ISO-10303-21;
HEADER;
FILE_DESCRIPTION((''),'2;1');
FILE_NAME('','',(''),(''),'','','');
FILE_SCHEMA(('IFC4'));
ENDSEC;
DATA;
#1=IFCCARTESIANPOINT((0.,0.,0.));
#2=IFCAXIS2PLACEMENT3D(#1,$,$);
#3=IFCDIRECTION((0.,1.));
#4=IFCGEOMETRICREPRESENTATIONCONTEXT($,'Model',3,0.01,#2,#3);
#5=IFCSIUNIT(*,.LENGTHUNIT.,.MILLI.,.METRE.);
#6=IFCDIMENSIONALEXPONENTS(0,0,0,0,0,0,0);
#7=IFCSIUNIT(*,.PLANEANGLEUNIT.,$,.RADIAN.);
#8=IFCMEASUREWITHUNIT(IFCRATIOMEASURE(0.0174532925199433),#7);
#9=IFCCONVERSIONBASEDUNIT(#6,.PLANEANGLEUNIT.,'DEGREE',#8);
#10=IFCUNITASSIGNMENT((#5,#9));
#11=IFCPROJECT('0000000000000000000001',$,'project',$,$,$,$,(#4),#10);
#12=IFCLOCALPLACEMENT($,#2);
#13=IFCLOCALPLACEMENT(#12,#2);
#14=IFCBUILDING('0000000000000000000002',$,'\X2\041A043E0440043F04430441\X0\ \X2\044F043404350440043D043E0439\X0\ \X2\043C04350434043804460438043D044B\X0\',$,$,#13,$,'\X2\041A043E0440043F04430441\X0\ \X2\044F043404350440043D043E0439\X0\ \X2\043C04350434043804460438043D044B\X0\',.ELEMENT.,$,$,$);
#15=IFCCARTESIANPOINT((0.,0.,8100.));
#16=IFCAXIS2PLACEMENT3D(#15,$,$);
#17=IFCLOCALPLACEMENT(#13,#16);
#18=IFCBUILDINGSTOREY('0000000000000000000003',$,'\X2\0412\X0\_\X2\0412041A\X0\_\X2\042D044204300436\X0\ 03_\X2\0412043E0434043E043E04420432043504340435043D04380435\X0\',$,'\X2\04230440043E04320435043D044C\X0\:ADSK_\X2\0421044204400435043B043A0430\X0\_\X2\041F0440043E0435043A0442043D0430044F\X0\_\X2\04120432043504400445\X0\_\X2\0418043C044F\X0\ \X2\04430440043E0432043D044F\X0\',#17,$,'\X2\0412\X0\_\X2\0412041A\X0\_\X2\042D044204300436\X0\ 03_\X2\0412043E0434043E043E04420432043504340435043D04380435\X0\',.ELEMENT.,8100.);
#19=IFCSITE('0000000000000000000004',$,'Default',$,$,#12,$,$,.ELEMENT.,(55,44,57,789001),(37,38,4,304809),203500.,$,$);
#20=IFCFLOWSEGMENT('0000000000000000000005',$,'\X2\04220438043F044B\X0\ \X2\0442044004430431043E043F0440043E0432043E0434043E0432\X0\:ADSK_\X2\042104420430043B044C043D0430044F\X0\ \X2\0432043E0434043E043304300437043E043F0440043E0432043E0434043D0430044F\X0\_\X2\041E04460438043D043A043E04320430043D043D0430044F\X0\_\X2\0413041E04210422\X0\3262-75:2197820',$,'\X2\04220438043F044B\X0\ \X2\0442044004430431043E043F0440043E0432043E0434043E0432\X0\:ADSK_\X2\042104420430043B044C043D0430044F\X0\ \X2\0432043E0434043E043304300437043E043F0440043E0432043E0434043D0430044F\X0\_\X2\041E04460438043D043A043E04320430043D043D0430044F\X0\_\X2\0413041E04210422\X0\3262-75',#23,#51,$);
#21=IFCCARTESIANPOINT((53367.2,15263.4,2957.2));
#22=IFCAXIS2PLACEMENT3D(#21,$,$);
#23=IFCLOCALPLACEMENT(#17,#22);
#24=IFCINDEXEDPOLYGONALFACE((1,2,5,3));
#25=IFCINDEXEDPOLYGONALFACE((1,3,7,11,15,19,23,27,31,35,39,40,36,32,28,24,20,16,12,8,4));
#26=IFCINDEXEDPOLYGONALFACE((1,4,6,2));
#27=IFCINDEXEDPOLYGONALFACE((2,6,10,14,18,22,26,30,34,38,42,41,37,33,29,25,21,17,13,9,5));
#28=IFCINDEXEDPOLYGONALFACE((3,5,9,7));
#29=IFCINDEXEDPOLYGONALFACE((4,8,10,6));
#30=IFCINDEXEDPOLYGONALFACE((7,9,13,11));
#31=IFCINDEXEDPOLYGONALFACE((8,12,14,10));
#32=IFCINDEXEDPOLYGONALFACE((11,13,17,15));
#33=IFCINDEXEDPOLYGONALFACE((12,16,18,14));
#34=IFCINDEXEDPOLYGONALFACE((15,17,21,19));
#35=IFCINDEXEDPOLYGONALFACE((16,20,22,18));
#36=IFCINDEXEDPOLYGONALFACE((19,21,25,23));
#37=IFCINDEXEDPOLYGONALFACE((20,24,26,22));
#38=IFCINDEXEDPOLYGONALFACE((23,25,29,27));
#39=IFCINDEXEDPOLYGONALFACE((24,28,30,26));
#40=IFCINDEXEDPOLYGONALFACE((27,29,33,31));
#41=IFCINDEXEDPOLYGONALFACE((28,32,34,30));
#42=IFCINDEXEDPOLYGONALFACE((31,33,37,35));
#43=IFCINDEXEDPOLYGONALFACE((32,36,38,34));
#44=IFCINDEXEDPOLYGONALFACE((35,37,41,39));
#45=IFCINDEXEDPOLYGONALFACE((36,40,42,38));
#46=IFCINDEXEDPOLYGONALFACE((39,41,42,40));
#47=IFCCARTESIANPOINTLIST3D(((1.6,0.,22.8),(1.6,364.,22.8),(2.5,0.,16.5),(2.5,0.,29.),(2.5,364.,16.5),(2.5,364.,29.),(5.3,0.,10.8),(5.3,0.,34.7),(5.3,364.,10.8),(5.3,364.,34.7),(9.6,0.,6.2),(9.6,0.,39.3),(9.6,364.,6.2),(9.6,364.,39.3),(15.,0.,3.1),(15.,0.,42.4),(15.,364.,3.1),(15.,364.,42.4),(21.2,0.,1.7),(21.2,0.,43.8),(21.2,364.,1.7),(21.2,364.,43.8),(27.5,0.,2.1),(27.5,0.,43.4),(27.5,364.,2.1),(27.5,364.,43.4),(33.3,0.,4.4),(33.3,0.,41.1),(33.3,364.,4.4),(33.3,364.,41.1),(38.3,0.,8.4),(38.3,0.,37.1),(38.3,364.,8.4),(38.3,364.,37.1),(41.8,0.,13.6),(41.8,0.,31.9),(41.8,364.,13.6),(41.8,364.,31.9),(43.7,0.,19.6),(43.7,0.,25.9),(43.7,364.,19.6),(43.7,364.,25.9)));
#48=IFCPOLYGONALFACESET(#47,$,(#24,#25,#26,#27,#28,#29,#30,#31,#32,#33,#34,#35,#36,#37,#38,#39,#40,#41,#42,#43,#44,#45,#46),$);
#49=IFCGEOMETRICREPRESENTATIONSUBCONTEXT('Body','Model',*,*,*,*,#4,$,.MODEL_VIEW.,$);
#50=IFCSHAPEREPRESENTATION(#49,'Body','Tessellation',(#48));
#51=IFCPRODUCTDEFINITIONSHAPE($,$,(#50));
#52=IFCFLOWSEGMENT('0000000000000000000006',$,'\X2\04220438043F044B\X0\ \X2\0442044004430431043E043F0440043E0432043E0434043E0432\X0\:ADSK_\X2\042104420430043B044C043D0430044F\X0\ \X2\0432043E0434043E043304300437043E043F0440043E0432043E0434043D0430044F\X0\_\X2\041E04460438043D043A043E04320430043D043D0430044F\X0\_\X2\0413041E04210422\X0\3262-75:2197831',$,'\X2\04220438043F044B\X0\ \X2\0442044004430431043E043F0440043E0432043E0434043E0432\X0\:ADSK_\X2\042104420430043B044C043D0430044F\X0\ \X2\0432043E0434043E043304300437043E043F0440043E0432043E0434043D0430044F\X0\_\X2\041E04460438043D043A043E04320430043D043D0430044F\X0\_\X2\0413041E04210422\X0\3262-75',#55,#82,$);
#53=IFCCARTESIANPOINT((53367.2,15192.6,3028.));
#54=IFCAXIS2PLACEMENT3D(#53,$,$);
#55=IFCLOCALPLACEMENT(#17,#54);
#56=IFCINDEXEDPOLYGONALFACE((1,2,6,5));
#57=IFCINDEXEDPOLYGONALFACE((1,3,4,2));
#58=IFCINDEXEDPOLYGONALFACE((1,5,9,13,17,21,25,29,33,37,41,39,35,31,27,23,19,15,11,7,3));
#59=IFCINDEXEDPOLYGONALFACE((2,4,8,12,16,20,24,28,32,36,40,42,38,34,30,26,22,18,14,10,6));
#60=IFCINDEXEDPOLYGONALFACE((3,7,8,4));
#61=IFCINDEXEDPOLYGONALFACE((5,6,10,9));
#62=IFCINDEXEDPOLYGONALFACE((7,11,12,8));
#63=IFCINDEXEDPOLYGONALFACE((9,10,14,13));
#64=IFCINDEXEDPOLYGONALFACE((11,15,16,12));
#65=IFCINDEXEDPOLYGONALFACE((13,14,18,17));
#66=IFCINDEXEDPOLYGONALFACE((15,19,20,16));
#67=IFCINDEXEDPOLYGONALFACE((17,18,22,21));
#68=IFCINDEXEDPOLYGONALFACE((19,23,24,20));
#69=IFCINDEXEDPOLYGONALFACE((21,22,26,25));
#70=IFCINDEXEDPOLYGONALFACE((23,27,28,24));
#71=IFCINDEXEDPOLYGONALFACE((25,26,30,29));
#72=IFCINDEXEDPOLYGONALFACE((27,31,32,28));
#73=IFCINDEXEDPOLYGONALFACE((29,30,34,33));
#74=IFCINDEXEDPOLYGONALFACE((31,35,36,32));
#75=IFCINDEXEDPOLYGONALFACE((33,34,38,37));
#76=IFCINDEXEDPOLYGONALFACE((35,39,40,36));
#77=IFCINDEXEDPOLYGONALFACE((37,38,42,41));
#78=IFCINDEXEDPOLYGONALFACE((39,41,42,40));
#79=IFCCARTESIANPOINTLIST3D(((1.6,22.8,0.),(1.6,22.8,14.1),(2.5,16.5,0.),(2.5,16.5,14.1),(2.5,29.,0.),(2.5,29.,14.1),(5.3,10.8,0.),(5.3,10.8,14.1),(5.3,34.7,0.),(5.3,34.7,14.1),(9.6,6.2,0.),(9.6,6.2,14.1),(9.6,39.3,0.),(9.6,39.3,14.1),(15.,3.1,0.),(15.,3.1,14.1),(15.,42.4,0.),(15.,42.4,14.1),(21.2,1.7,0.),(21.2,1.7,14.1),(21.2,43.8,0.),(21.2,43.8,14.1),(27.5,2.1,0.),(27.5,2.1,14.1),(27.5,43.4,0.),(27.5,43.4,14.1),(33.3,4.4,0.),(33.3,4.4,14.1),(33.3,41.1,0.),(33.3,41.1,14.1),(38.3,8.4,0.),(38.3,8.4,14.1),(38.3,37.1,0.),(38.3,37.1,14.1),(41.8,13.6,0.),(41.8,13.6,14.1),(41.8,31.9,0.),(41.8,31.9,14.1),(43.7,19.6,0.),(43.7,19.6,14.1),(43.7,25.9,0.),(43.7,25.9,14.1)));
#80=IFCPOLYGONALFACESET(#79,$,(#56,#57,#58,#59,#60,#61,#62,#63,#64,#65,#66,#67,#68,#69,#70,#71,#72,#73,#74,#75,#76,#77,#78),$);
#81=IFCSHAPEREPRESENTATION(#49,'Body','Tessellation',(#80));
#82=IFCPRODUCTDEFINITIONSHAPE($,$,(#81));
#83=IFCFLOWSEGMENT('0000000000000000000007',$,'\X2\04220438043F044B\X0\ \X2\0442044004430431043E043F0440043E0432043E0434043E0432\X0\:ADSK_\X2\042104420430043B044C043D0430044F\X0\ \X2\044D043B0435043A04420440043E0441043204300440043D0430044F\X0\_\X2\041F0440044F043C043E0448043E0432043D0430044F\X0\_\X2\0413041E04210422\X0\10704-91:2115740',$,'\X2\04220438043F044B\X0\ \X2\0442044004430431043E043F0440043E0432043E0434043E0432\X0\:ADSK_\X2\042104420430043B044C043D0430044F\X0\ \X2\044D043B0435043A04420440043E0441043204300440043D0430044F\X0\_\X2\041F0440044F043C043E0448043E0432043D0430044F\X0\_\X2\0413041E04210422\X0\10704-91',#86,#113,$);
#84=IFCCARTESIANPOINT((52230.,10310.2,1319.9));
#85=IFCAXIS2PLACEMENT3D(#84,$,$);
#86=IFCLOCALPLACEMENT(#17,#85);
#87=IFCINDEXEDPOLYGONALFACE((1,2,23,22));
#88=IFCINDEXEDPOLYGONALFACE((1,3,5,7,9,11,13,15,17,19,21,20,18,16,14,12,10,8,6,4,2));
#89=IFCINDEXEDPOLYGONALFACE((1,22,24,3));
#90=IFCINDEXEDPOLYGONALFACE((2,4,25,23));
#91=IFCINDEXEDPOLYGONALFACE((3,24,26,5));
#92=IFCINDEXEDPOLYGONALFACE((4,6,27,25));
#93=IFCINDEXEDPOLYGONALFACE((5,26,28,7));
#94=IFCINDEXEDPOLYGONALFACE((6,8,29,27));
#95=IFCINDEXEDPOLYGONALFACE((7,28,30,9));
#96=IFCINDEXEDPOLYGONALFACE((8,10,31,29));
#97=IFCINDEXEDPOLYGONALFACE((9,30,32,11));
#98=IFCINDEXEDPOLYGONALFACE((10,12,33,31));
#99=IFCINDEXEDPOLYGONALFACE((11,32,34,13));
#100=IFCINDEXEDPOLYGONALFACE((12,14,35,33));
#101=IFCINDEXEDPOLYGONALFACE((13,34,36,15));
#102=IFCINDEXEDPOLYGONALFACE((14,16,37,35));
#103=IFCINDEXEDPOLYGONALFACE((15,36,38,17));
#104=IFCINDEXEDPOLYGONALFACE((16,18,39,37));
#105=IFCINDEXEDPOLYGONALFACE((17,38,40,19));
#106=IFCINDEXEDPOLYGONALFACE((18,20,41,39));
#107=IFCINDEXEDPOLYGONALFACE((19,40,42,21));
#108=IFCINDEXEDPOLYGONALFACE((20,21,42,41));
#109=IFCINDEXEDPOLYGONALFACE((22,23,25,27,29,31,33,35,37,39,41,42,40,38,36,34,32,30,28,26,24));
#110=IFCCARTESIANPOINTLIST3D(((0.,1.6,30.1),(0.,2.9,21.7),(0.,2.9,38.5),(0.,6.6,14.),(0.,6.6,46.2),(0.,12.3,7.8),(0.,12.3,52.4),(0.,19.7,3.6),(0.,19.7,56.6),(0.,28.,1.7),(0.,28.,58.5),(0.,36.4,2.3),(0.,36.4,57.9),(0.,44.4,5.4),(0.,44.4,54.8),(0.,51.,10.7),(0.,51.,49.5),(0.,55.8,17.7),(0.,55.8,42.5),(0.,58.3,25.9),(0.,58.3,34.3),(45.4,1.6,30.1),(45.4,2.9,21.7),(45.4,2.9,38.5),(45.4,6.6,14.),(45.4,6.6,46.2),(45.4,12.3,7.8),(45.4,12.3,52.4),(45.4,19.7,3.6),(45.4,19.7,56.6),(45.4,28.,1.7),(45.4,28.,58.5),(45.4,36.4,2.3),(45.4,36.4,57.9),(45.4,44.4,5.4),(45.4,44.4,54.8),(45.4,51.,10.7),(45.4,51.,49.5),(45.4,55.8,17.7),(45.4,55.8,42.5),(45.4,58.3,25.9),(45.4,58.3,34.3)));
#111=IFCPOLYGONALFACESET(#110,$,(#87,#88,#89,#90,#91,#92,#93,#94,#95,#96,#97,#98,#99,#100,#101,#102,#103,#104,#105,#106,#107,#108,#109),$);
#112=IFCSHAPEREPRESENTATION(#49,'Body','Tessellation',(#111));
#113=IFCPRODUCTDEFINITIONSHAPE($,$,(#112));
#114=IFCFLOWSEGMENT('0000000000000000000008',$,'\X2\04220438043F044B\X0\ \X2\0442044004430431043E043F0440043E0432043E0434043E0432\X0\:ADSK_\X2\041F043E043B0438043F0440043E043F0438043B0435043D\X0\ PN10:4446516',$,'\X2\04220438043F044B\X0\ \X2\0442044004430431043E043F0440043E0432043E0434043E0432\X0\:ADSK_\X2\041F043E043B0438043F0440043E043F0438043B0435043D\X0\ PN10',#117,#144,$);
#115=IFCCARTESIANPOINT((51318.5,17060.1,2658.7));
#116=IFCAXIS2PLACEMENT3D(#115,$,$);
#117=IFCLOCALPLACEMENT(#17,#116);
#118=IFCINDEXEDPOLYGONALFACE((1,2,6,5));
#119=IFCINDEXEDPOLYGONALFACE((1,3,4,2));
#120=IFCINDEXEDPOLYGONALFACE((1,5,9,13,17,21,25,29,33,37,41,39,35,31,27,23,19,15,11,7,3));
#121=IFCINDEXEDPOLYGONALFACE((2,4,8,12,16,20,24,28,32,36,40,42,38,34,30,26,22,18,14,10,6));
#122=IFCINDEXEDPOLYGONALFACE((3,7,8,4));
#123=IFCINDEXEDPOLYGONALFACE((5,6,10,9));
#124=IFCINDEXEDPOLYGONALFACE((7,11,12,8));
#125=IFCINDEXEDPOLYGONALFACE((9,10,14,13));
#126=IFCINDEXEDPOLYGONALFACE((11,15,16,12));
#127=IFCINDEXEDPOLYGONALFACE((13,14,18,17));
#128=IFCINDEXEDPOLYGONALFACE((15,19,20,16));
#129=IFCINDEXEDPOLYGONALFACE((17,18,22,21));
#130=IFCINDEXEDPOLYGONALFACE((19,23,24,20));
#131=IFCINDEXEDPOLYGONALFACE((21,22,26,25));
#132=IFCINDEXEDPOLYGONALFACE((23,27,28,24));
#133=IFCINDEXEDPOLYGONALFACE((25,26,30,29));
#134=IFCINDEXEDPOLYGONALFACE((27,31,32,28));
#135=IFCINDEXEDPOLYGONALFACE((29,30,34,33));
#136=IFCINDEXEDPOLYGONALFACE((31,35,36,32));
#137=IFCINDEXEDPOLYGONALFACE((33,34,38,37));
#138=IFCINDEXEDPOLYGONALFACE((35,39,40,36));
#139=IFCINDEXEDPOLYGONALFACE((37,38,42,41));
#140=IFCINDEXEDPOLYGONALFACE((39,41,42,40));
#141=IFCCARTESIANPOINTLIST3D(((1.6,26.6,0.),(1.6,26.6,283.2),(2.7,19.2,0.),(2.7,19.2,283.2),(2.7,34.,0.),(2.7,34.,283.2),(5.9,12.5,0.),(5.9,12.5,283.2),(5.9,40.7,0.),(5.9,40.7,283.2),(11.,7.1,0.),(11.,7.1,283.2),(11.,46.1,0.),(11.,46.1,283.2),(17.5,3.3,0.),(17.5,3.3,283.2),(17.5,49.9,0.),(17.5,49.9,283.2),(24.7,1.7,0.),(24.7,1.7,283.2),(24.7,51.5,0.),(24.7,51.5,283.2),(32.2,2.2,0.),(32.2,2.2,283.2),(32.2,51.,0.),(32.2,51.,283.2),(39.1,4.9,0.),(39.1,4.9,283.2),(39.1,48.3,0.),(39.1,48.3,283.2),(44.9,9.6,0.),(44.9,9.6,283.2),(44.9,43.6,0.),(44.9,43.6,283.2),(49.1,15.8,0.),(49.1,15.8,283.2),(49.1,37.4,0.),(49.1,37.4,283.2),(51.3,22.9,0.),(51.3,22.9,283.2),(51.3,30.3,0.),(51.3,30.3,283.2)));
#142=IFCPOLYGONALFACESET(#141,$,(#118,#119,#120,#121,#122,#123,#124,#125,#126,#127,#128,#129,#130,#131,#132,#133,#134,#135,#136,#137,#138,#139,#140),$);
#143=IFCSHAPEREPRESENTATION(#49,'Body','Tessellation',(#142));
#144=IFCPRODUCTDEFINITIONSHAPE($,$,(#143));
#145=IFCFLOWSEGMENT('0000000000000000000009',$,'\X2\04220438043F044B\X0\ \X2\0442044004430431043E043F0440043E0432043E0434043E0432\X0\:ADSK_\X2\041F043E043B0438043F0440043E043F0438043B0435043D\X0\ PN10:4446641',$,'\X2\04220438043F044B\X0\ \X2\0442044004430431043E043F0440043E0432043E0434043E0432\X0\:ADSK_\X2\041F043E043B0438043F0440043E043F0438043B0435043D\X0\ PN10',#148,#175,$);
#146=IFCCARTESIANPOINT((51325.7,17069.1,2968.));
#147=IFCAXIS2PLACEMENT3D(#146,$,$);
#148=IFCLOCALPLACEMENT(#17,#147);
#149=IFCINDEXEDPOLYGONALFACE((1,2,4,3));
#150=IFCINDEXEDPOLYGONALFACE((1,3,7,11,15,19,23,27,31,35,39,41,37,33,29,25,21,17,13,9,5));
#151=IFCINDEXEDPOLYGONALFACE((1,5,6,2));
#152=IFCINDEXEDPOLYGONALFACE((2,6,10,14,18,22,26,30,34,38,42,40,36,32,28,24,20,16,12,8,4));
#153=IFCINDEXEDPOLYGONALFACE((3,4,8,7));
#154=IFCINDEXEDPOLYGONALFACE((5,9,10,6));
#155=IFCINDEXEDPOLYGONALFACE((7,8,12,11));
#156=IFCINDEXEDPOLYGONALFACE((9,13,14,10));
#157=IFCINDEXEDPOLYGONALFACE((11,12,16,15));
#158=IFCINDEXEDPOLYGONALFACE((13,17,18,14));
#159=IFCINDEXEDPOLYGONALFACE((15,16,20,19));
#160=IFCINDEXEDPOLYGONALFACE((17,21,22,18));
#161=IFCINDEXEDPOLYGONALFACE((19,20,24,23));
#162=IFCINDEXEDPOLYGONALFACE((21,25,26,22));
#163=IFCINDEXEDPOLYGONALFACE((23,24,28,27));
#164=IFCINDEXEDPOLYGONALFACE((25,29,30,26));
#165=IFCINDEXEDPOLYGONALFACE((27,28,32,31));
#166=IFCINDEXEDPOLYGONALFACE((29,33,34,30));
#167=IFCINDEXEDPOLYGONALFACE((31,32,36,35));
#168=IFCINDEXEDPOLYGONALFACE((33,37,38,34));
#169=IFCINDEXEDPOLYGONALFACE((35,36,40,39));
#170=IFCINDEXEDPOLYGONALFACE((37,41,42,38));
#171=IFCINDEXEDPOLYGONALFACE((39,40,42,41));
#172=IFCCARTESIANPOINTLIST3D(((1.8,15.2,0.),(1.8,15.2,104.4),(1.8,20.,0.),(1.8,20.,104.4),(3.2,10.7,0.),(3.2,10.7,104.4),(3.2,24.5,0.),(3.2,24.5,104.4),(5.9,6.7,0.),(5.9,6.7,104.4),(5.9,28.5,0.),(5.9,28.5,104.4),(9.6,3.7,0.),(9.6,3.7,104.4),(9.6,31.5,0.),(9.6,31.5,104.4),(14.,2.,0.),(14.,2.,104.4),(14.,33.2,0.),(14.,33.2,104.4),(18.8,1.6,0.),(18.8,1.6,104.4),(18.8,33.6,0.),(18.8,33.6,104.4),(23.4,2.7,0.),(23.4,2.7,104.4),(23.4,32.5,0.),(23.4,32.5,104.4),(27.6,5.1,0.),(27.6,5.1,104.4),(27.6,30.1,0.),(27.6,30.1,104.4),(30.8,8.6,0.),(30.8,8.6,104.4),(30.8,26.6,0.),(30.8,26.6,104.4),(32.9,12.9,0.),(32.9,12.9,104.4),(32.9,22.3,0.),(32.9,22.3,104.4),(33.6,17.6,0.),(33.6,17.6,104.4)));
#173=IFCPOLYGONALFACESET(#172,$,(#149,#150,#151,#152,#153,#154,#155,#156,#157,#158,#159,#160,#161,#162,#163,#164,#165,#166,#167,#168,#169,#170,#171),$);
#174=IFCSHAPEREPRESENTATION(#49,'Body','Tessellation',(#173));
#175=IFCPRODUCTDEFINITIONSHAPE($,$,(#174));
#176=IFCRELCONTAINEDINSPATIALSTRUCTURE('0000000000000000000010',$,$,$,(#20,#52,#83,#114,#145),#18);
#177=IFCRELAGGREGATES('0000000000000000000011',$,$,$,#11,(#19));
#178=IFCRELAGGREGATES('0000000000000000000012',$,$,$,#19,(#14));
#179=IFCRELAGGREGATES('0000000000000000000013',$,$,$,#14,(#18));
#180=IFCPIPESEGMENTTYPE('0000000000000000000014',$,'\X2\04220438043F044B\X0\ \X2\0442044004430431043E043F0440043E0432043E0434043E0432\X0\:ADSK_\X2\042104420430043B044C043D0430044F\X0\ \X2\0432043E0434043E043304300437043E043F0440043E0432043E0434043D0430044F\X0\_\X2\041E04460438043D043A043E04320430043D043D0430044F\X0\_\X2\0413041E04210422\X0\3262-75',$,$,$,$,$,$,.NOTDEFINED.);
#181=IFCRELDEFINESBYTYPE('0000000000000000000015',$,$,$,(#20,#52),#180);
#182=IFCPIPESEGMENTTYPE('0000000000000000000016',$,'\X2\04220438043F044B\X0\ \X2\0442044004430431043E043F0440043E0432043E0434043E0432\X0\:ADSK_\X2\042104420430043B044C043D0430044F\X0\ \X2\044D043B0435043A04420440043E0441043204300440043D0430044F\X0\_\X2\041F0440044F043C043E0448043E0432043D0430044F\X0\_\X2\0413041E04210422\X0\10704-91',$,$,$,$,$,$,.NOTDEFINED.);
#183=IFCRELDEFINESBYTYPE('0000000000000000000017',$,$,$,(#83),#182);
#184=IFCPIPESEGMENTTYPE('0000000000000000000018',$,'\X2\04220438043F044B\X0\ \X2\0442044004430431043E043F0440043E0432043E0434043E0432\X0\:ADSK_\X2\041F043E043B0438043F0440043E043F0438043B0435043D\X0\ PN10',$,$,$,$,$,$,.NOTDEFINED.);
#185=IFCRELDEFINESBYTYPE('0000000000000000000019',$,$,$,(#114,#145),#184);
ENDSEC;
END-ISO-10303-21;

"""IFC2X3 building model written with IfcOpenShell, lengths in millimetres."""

from ifc_helpers import new_model, entity, si_unit, converted_unit, direction, frame, origin, origin_2d_with_axis, place, context, subcontext, project, spatial, circle, extrude, type_object, element, save


model = new_model("IFC2X3")

# Units and contexts
model_context = context("Model", 3, precision=0.01, world=origin(), true_north=direction((0.0, 1.0)))
body_context = subcontext(model_context, "Body", "Model", "MODEL_VIEW")
ifc_project = project(units=[si_unit("LENGTHUNIT", "METRE", prefix="MILLI"), converted_unit("PLANEANGLEUNIT", "DEGREE", entity("IfcRatioMeasure", 0.0174532925199433), si_unit("PLANEANGLEUNIT", "RADIAN"), dimensions=[0, 0, 0, 0, 0, 0, 0])], contexts=[model_context])

# Site, building, storey
site_placement = place(None, origin())
site = spatial("IfcSite", under=ifc_project, at=site_placement, Name="Default", CompositionType="ELEMENT", RefLatitude=(55, 44, 57, 789001), RefLongitude=(37, 38, 4, 304809), RefElevation=203500.0)
building_placement = place(site_placement, origin())
building = spatial("IfcBuilding", under=site, at=building_placement, Name="Корпус ядерной медицины", LongName="Корпус ядерной медицины", CompositionType="ELEMENT")
storey_placement = place(building_placement, frame((0.0, 0.0, 8100.0)))
storey = spatial("IfcBuildingStorey", under=building, at=storey_placement, Name="В_ВК_Этаж 03_Водоотведение", ObjectType="Уровень:ADSK_Стрелка_Проектная_Вверх_Имя уровня", LongName="В_ВК_Этаж 03_Водоотведение", CompositionType="ELEMENT", Elevation=8100.0)

# Flow segments
pipe_segment_type_1 = type_object("IfcPipeSegmentType", Name="Типы трубопроводов:ADSK_Стальная водогазопроводная_Оцинкованная_ГОСТ3262-75", PredefinedType="NOTDEFINED")
flow_segment_1_placement = place(storey_placement, frame((53367.2, 15263.4, 2957.2)))
element("IfcFlowSegment", 1, at=flow_segment_1_placement, inside=storey, type_object=pipe_segment_type_1, Name="Типы трубопроводов:ADSK_Стальная водогазопроводная_Оцинкованная_ГОСТ3262-75:2197820", ObjectType="Типы трубопроводов:ADSK_Стальная водогазопроводная_Оцинкованная_ГОСТ3262-75", context=body_context, shape_type="SweptSolid", body=[
    extrude(circle(Radius=21.1, at=origin_2d_with_axis()), frame((22.8, 0.0, 22.8), z_axis=(0.0, 1.0, 0.0), x_axis=(-1.0, 0.0, 0.0)), (0.0, 0.0, 1.0), 364.0),
])
flow_segment_2_placement = place(storey_placement, frame((53367.2, 15192.6, 3028.0)))
element("IfcFlowSegment", 2, at=flow_segment_2_placement, inside=storey, type_object=pipe_segment_type_1, Name="Типы трубопроводов:ADSK_Стальная водогазопроводная_Оцинкованная_ГОСТ3262-75:2197831", ObjectType="Типы трубопроводов:ADSK_Стальная водогазопроводная_Оцинкованная_ГОСТ3262-75", context=body_context, shape_type="SweptSolid", body=[
    extrude(circle(Radius=21.1, at=origin_2d_with_axis()), frame((22.8, 22.8, 0.0), z_axis=(0.0, 0.0, 1.0), x_axis=(-1.0, 0.0, 0.0)), (0.0, 0.0, 1.0), 14.1),
])
pipe_segment_type_2 = type_object("IfcPipeSegmentType", Name="Типы трубопроводов:ADSK_Стальная электросварная_Прямошовная_ГОСТ10704-91", PredefinedType="NOTDEFINED")
flow_segment_3_placement = place(storey_placement, frame((52230.0, 10310.2, 1319.9)))
element("IfcFlowSegment", 3, at=flow_segment_3_placement, inside=storey, type_object=pipe_segment_type_2, Name="Типы трубопроводов:ADSK_Стальная электросварная_Прямошовная_ГОСТ10704-91:2115740", ObjectType="Типы трубопроводов:ADSK_Стальная электросварная_Прямошовная_ГОСТ10704-91", context=body_context, shape_type="SweptSolid", body=[
    extrude(circle(Radius=28.5, at=origin_2d_with_axis()), frame((0.0, 30.1, 30.1), z_axis=(1.0, 0.0, 0.0), x_axis=(0.0, -1.0, 0.0)), (0.0, 0.0, 1.0), 45.4),
])
pipe_segment_type_3 = type_object("IfcPipeSegmentType", Name="Типы трубопроводов:ADSK_Полипропилен PN10", PredefinedType="NOTDEFINED")
flow_segment_4_placement = place(storey_placement, frame((51318.5, 17060.1, 2658.7)))
element("IfcFlowSegment", 4, at=flow_segment_4_placement, inside=storey, type_object=pipe_segment_type_3, Name="Типы трубопроводов:ADSK_Полипропилен PN10:4446516", ObjectType="Типы трубопроводов:ADSK_Полипропилен PN10", context=body_context, shape_type="SweptSolid", body=[
    extrude(circle(Radius=25.0, at=origin_2d_with_axis()), frame((26.6, 26.6, 0.0), z_axis=(0.0, 0.0, 1.0), x_axis=(-1.0, 0.0, 0.0)), (0.0, 0.0, 1.0), 283.2),
])
flow_segment_5_placement = place(storey_placement, frame((51325.7, 17069.1, 2968.0)))
element("IfcFlowSegment", 5, at=flow_segment_5_placement, inside=storey, type_object=pipe_segment_type_3, Name="Типы трубопроводов:ADSK_Полипропилен PN10:4446641", ObjectType="Типы трубопроводов:ADSK_Полипропилен PN10", context=body_context, shape_type="SweptSolid", body=[
    extrude(circle(Radius=16.0, at=origin_2d_with_axis()), frame((17.6, 17.6, 0.0)), (0.0, 0.0, 1.0), 104.4),
])

save(model, "model.ifc")
